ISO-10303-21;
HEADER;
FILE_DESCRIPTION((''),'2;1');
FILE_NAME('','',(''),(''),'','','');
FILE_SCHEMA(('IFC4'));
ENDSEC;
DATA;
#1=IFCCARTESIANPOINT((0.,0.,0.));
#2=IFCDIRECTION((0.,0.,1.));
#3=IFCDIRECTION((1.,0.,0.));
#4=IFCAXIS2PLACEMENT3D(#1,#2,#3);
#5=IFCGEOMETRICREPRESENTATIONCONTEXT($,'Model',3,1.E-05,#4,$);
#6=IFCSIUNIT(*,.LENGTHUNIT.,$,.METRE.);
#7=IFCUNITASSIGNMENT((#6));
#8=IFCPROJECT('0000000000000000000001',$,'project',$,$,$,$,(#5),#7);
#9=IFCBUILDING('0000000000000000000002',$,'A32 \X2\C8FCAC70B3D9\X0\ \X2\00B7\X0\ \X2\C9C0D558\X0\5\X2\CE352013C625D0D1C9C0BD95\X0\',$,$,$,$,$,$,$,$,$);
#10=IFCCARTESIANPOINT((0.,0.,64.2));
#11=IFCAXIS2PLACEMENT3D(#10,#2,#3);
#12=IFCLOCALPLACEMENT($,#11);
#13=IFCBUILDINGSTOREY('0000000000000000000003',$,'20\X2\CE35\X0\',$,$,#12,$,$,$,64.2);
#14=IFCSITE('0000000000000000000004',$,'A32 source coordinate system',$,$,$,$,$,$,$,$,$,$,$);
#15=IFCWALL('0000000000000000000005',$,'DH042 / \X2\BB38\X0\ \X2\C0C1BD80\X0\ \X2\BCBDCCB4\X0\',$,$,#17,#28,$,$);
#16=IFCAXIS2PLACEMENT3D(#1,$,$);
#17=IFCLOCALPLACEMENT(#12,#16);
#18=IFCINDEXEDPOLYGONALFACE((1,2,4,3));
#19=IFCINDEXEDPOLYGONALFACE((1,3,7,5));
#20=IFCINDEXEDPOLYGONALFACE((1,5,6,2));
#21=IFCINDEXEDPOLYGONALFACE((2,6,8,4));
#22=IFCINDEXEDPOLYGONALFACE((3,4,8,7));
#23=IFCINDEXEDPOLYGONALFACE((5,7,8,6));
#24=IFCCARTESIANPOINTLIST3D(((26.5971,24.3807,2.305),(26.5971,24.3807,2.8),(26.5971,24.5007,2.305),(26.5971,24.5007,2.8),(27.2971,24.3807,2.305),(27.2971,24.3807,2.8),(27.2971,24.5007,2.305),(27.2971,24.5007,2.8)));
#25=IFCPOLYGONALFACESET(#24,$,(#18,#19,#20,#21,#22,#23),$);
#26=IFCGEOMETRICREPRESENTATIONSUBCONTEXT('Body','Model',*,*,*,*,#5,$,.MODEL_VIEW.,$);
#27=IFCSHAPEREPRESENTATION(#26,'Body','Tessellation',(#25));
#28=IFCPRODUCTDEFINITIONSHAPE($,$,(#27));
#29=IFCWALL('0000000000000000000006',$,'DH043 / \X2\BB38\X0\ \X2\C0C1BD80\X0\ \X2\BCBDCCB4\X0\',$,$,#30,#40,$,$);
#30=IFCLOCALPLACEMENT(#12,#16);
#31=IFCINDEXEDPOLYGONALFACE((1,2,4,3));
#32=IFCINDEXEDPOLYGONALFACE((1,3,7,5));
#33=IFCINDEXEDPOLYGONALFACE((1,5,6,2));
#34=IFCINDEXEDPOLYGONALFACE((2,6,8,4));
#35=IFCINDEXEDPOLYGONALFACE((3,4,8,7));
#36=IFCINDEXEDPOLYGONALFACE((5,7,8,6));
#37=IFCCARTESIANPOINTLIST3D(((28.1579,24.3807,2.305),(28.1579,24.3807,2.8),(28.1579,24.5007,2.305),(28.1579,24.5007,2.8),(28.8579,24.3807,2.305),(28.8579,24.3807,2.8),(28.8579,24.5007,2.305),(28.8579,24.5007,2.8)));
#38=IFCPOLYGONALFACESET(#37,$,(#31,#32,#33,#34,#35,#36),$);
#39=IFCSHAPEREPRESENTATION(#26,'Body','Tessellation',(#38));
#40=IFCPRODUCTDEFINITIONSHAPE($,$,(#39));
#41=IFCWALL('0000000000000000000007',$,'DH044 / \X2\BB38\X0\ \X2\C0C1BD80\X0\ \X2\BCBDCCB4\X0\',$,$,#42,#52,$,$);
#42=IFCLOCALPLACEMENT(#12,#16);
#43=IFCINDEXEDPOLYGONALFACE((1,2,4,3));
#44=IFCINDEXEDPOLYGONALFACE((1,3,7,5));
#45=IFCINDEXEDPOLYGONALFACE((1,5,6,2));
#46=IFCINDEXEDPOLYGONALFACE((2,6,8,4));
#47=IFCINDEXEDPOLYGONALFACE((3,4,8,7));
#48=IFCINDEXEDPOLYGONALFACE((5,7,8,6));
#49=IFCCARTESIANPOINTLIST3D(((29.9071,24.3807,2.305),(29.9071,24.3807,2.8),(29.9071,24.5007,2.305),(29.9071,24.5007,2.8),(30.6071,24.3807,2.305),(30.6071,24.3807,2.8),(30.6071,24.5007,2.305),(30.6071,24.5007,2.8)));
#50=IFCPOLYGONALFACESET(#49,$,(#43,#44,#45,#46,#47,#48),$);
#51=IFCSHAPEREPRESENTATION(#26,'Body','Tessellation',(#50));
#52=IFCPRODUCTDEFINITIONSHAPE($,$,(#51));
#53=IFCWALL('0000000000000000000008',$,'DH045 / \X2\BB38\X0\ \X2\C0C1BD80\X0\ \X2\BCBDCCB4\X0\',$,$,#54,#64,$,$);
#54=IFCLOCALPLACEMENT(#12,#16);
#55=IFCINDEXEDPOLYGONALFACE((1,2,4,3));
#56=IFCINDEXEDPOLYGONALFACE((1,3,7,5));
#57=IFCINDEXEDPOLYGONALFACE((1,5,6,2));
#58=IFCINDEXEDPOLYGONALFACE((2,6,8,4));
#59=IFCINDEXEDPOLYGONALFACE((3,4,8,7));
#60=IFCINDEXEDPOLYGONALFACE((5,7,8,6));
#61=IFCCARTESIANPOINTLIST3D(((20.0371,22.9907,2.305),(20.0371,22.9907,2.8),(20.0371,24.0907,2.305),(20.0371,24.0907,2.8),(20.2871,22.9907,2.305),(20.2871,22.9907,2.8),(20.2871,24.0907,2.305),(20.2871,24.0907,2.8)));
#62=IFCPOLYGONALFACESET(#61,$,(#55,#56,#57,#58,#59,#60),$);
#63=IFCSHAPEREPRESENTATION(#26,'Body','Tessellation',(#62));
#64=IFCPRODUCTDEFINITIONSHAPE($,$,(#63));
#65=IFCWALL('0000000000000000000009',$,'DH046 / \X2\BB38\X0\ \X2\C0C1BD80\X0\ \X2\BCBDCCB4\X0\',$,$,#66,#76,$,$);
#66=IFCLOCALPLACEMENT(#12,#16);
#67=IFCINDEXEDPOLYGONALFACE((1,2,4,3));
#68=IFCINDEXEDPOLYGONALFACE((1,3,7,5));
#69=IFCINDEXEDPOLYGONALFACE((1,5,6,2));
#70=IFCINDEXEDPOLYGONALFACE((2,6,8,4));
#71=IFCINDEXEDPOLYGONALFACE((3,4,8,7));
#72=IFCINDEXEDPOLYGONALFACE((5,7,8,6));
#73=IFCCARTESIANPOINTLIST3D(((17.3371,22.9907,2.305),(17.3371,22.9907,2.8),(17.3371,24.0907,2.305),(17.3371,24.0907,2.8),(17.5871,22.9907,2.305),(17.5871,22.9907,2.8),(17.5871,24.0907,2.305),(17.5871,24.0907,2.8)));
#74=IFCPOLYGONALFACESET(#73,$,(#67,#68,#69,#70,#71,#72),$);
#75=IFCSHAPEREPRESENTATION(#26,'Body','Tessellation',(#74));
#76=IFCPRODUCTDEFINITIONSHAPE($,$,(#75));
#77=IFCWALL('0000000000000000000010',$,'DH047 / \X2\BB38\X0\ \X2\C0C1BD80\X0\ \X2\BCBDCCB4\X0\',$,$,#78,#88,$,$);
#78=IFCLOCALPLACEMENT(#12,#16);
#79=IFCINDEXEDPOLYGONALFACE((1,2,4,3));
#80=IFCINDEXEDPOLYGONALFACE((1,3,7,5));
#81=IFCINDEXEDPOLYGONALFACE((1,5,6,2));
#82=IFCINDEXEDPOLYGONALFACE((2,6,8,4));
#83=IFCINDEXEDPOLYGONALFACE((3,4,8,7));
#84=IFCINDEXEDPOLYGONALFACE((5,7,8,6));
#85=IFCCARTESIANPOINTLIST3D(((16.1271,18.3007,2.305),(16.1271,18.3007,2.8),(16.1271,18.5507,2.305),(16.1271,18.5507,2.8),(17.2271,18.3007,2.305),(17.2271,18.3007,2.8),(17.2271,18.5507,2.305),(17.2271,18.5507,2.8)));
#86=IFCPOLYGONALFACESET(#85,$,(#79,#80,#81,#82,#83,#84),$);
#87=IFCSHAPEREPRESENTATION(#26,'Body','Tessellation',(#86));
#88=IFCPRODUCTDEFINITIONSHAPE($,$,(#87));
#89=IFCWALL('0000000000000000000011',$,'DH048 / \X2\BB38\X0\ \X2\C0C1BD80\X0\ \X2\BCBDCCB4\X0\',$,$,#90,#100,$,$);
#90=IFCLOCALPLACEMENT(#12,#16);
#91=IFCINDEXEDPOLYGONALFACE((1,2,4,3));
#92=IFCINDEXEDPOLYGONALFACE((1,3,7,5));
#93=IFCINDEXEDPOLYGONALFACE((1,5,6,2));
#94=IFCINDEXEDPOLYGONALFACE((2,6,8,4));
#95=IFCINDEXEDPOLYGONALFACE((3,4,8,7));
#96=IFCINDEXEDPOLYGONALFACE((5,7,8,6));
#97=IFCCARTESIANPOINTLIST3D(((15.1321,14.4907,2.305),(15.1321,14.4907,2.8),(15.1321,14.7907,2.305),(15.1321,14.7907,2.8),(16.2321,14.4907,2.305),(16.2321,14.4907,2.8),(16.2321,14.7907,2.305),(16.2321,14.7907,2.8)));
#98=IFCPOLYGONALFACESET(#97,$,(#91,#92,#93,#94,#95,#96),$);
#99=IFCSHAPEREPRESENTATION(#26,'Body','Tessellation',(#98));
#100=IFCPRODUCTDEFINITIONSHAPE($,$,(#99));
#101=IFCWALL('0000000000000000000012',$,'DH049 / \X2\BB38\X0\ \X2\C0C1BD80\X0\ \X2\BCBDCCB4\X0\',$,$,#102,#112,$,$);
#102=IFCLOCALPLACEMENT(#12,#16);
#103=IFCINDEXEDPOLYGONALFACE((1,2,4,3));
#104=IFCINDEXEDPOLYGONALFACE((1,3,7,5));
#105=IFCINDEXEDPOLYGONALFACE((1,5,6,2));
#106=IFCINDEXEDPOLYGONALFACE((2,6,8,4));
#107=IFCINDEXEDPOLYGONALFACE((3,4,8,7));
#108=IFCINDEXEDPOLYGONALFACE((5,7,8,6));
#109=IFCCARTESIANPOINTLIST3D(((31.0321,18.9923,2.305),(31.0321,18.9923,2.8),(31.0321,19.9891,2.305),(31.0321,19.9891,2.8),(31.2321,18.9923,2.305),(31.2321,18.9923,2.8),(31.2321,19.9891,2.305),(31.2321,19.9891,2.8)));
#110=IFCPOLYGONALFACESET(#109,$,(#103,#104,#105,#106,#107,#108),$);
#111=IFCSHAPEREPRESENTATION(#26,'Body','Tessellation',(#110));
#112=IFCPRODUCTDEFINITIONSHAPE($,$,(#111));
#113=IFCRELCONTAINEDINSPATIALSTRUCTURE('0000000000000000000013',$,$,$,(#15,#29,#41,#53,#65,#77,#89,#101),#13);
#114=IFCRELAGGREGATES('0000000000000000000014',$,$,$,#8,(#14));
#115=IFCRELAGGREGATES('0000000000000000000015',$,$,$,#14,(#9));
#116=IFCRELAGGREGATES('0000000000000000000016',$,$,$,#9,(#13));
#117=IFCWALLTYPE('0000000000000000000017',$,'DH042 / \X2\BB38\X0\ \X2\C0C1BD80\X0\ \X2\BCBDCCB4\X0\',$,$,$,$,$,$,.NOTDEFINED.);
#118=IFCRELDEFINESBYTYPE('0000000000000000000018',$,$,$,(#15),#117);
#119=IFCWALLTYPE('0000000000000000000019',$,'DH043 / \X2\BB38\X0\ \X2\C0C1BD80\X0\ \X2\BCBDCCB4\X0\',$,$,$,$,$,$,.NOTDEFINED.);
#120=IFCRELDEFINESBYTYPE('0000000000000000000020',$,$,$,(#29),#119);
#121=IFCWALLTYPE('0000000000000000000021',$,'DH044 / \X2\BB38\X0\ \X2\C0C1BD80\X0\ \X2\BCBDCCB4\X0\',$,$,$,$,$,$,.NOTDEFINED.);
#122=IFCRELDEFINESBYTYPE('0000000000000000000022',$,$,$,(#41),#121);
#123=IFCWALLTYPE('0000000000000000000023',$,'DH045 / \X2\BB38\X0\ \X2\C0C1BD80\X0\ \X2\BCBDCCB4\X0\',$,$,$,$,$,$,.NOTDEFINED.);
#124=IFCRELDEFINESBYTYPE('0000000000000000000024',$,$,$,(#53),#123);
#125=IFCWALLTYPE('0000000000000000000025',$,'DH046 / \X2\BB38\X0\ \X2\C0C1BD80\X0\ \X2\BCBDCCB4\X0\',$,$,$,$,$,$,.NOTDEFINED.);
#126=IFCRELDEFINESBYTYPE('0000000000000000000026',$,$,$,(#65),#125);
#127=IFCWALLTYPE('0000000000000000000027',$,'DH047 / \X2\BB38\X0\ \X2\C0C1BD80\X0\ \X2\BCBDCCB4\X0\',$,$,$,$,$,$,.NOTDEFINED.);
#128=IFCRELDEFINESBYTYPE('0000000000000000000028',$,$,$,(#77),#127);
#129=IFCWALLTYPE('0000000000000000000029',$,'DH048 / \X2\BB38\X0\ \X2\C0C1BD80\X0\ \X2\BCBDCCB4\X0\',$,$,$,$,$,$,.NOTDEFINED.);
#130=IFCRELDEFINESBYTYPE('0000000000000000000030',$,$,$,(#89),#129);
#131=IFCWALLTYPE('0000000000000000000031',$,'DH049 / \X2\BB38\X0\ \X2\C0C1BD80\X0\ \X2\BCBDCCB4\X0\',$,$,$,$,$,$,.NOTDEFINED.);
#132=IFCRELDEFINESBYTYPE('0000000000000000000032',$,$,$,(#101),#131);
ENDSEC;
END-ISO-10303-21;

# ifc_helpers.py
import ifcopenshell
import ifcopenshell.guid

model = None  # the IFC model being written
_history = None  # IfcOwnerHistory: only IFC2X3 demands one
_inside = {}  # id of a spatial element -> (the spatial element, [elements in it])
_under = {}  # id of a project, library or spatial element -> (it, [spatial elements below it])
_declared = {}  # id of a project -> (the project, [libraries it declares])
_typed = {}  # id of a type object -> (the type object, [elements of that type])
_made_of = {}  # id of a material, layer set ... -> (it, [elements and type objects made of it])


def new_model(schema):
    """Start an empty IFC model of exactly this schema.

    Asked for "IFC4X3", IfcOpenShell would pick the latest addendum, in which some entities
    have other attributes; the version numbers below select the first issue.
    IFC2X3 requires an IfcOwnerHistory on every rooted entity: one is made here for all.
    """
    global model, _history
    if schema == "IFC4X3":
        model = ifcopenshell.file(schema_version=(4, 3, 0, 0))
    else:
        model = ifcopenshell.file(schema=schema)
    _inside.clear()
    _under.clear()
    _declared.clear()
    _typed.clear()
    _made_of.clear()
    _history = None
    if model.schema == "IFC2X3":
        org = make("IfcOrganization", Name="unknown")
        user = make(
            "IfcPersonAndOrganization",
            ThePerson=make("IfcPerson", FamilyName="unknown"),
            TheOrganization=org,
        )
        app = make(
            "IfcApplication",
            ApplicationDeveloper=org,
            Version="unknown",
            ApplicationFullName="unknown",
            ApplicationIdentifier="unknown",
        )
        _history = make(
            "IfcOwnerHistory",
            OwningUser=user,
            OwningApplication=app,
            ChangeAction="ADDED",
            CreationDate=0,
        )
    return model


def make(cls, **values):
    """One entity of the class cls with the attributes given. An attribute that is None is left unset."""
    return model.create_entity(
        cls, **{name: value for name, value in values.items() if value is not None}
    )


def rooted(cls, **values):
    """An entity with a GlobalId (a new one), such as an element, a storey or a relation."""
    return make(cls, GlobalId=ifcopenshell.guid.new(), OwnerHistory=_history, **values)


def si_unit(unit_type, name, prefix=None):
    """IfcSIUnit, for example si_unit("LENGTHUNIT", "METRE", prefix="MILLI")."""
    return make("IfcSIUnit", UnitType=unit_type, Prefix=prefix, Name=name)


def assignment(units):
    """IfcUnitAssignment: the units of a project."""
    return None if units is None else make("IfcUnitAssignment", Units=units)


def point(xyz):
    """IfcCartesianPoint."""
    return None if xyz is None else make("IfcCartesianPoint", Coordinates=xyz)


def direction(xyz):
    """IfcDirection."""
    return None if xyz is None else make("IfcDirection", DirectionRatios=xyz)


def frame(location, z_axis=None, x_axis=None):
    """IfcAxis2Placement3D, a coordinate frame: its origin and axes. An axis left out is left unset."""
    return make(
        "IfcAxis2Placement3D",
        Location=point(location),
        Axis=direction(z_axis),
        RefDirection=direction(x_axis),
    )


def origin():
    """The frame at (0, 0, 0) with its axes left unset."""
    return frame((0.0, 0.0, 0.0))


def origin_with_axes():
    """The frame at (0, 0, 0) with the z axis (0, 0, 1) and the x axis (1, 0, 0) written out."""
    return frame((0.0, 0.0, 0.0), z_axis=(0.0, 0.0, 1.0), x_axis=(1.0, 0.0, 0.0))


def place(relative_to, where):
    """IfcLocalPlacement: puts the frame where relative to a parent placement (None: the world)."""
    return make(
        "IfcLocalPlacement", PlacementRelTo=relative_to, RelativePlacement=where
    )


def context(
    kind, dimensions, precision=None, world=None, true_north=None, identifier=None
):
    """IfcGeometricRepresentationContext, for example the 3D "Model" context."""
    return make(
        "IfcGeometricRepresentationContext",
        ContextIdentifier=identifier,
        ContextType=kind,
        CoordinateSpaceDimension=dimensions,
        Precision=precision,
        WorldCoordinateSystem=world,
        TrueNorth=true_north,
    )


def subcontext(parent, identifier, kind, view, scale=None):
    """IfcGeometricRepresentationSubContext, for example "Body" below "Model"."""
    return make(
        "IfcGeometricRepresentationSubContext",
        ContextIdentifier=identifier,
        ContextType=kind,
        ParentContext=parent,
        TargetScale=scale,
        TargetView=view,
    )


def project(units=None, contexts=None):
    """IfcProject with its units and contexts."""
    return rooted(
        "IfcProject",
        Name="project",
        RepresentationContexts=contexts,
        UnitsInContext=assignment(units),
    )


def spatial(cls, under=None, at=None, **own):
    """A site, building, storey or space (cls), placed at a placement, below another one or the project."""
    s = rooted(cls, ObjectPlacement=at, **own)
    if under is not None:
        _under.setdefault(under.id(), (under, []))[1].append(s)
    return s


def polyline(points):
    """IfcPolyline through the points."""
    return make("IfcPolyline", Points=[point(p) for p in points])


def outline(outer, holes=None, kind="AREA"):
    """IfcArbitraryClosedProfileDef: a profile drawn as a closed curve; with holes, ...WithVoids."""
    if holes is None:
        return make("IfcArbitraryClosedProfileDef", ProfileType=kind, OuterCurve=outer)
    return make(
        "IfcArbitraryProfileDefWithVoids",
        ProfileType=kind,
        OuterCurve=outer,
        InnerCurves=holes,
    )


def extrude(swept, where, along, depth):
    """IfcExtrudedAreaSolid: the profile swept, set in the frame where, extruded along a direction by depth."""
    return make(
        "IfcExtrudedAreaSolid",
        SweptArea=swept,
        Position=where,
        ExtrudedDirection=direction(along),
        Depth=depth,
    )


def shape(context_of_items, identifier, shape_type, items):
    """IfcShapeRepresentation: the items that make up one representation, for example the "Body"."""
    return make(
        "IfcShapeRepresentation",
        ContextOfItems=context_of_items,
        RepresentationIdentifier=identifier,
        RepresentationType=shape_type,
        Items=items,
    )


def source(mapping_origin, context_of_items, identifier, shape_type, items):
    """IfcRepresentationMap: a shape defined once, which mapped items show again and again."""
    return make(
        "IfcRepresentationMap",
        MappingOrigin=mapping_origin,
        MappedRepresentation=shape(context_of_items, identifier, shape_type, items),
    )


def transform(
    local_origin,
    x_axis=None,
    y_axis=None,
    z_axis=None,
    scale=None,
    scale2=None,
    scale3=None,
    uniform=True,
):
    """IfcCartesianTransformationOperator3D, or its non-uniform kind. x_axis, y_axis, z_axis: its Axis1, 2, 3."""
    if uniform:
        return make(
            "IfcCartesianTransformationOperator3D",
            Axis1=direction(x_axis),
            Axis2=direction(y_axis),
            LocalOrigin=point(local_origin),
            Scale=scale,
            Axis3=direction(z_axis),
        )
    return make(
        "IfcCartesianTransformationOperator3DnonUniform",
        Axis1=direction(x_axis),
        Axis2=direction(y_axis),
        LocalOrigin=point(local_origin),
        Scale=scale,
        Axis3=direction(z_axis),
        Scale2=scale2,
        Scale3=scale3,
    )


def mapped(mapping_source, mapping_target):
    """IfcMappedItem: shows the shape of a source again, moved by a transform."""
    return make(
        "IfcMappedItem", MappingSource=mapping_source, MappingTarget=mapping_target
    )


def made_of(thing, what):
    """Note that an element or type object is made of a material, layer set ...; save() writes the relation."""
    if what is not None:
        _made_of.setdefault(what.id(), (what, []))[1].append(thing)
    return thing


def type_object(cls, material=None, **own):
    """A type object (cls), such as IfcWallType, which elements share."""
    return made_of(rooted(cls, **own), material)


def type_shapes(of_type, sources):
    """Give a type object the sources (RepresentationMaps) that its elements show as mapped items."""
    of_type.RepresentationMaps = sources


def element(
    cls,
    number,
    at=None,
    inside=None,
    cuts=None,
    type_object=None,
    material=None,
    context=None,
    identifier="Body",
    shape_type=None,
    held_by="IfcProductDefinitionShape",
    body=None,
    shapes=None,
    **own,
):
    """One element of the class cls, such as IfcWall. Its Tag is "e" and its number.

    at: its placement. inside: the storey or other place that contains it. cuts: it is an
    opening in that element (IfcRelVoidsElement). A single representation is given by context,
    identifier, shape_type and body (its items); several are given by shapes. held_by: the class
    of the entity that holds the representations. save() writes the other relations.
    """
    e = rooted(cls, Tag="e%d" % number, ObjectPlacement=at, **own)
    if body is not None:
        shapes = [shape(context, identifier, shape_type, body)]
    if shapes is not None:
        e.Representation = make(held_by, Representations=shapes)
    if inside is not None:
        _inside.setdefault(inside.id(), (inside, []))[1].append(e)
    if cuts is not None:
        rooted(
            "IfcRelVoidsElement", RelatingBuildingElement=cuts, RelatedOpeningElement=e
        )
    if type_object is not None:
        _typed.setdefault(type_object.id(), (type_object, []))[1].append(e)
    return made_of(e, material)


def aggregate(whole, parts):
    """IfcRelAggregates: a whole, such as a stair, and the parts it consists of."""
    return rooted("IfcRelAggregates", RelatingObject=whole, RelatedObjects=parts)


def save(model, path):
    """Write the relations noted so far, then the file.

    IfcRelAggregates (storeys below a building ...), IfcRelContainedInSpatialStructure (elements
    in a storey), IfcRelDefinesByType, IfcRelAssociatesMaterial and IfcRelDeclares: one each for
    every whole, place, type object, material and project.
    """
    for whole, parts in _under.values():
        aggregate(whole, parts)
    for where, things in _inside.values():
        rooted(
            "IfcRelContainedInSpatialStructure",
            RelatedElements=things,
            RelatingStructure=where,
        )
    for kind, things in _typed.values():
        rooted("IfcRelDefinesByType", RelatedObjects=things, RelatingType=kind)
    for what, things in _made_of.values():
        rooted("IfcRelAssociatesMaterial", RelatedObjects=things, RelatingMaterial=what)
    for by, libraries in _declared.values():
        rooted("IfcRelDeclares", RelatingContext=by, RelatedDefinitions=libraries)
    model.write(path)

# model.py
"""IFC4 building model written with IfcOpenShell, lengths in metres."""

from ifc_helpers import new_model, si_unit, frame, origin, origin_with_axes, place, context, subcontext, project, spatial, polyline, outline, extrude, source, transform, mapped, type_object, type_shapes, element, save


model = new_model("IFC4")

# Units and contexts
model_context = context("Model", 3, precision=1e-05, world=origin_with_axes())
body_context = subcontext(model_context, "Body", "Model", "MODEL_VIEW")
ifc_project = project(units=[si_unit("LENGTHUNIT", "METRE")], contexts=[model_context])

# Site, building, storey
site = spatial("IfcSite", under=ifc_project, Name="A32 source coordinate system")
building = spatial("IfcBuilding", under=site, Name="A32 주거동 · 지하5층–옥탑지붕")
storey_placement = place(None, frame((0.0, 0.0, 64.2), z_axis=(0.0, 0.0, 1.0), x_axis=(1.0, 0.0, 0.0)))
storey = spatial("IfcBuildingStorey", under=building, at=storey_placement, Name="20층", Elevation=64.2)

# Walls
wall_type_1 = type_object("IfcWallType", Name="DH042 / 문 상부 벽체", PredefinedType="NOTDEFINED")
shared_shape_1 = source(origin(), body_context, "Body", "SweptSolid", [
    extrude(outline(polyline([(27.2971, 24.3807), (26.5971, 24.3807), (26.5971, 24.5007), (27.2971, 24.5007), (27.2971, 24.3807)])), frame((0.0, 0.0, 2.305)), (0.0, 0.0, 1.0), 0.495),
])
type_shapes(wall_type_1, [shared_shape_1])
wall_1_placement = place(storey_placement, origin_with_axes())
element("IfcWall", 1, at=wall_1_placement, inside=storey, type_object=wall_type_1, Name="DH042 / 문 상부 벽체", context=body_context, shape_type="MappedRepresentation", body=[
    mapped(shared_shape_1, transform((0.0, 0.0, 0.0), scale=1.0)),
])
wall_type_2 = type_object("IfcWallType", Name="DH043 / 문 상부 벽체", PredefinedType="NOTDEFINED")
shared_shape_2 = source(origin(), body_context, "Body", "SweptSolid", [
    extrude(outline(polyline([(28.8579, 24.3807), (28.1579, 24.3807), (28.1579, 24.5007), (28.8579, 24.5007), (28.8579, 24.3807)])), frame((0.0, 0.0, 2.305)), (0.0, 0.0, 1.0), 0.495),
])
type_shapes(wall_type_2, [shared_shape_2])
wall_2_placement = place(storey_placement, origin_with_axes())
element("IfcWall", 2, at=wall_2_placement, inside=storey, type_object=wall_type_2, Name="DH043 / 문 상부 벽체", context=body_context, shape_type="MappedRepresentation", body=[
    mapped(shared_shape_2, transform((0.0, 0.0, 0.0), scale=1.0)),
])
wall_type_3 = type_object("IfcWallType", Name="DH044 / 문 상부 벽체", PredefinedType="NOTDEFINED")
shared_shape_3 = source(origin(), body_context, "Body", "SweptSolid", [
    extrude(outline(polyline([(30.6071, 24.3807), (29.9071, 24.3807), (29.9071, 24.5007), (30.6071, 24.5007), (30.6071, 24.3807)])), frame((0.0, 0.0, 2.305)), (0.0, 0.0, 1.0), 0.495),
])
type_shapes(wall_type_3, [shared_shape_3])
wall_3_placement = place(storey_placement, origin_with_axes())
element("IfcWall", 3, at=wall_3_placement, inside=storey, type_object=wall_type_3, Name="DH044 / 문 상부 벽체", context=body_context, shape_type="MappedRepresentation", body=[
    mapped(shared_shape_3, transform((0.0, 0.0, 0.0), scale=1.0)),
])
wall_type_4 = type_object("IfcWallType", Name="DH045 / 문 상부 벽체", PredefinedType="NOTDEFINED")
shared_shape_4 = source(origin(), body_context, "Body", "SweptSolid", [
    extrude(outline(polyline([(20.2871, 22.9907), (20.0371, 22.9907), (20.0371, 24.0907), (20.2871, 24.0907), (20.2871, 22.9907)])), frame((0.0, 0.0, 2.305)), (0.0, 0.0, 1.0), 0.495),
])
type_shapes(wall_type_4, [shared_shape_4])
wall_4_placement = place(storey_placement, origin_with_axes())
element("IfcWall", 4, at=wall_4_placement, inside=storey, type_object=wall_type_4, Name="DH045 / 문 상부 벽체", context=body_context, shape_type="MappedRepresentation", body=[
    mapped(shared_shape_4, transform((0.0, 0.0, 0.0), scale=1.0)),
])
wall_type_5 = type_object("IfcWallType", Name="DH046 / 문 상부 벽체", PredefinedType="NOTDEFINED")
shared_shape_5 = source(origin(), body_context, "Body", "SweptSolid", [
    extrude(outline(polyline([(17.5871, 22.9907), (17.3371, 22.9907), (17.3371, 24.0907), (17.5871, 24.0907), (17.5871, 22.9907)])), frame((0.0, 0.0, 2.305)), (0.0, 0.0, 1.0), 0.495),
])
type_shapes(wall_type_5, [shared_shape_5])
wall_5_placement = place(storey_placement, origin_with_axes())
element("IfcWall", 5, at=wall_5_placement, inside=storey, type_object=wall_type_5, Name="DH046 / 문 상부 벽체", context=body_context, shape_type="MappedRepresentation", body=[
    mapped(shared_shape_5, transform((0.0, 0.0, 0.0), scale=1.0)),
])
wall_type_6 = type_object("IfcWallType", Name="DH047 / 문 상부 벽체", PredefinedType="NOTDEFINED")
shared_shape_6 = source(origin(), body_context, "Body", "SweptSolid", [
    extrude(outline(polyline([(17.2271, 18.3007), (16.1271, 18.3007), (16.1271, 18.5507), (17.2271, 18.5507), (17.2271, 18.3007)])), frame((0.0, 0.0, 2.305)), (0.0, 0.0, 1.0), 0.495),
])
type_shapes(wall_type_6, [shared_shape_6])
wall_6_placement = place(storey_placement, origin_with_axes())
element("IfcWall", 6, at=wall_6_placement, inside=storey, type_object=wall_type_6, Name="DH047 / 문 상부 벽체", context=body_context, shape_type="MappedRepresentation", body=[
    mapped(shared_shape_6, transform((0.0, 0.0, 0.0), scale=1.0)),
])
wall_type_7 = type_object("IfcWallType", Name="DH048 / 문 상부 벽체", PredefinedType="NOTDEFINED")
shared_shape_7 = source(origin(), body_context, "Body", "SweptSolid", [
    extrude(outline(polyline([(15.1321, 14.7907), (16.2321, 14.7907), (16.2321, 14.4907), (15.1321, 14.4907), (15.1321, 14.7907)])), frame((0.0, 0.0, 2.305)), (0.0, 0.0, 1.0), 0.495),
])
type_shapes(wall_type_7, [shared_shape_7])
wall_7_placement = place(storey_placement, origin_with_axes())
element("IfcWall", 7, at=wall_7_placement, inside=storey, type_object=wall_type_7, Name="DH048 / 문 상부 벽체", context=body_context, shape_type="MappedRepresentation", body=[
    mapped(shared_shape_7, transform((0.0, 0.0, 0.0), scale=1.0)),
])
wall_type_8 = type_object("IfcWallType", Name="DH049 / 문 상부 벽체", PredefinedType="NOTDEFINED")
shared_shape_8 = source(origin(), body_context, "Body", "SweptSolid", [
    extrude(outline(polyline([(31.2321, 18.9923), (31.0321, 18.9923), (31.0321, 19.9891), (31.2321, 19.9891), (31.2321, 18.9923)])), frame((0.0, 0.0, 2.305)), (0.0, 0.0, 1.0), 0.495),
])
type_shapes(wall_type_8, [shared_shape_8])
wall_8_placement = place(storey_placement, origin_with_axes())
element("IfcWall", 8, at=wall_8_placement, inside=storey, type_object=wall_type_8, Name="DH049 / 문 상부 벽체", context=body_context, shape_type="MappedRepresentation", body=[
    mapped(shared_shape_8, transform((0.0, 0.0, 0.0), scale=1.0)),
])

save(model, "model.ifc")
